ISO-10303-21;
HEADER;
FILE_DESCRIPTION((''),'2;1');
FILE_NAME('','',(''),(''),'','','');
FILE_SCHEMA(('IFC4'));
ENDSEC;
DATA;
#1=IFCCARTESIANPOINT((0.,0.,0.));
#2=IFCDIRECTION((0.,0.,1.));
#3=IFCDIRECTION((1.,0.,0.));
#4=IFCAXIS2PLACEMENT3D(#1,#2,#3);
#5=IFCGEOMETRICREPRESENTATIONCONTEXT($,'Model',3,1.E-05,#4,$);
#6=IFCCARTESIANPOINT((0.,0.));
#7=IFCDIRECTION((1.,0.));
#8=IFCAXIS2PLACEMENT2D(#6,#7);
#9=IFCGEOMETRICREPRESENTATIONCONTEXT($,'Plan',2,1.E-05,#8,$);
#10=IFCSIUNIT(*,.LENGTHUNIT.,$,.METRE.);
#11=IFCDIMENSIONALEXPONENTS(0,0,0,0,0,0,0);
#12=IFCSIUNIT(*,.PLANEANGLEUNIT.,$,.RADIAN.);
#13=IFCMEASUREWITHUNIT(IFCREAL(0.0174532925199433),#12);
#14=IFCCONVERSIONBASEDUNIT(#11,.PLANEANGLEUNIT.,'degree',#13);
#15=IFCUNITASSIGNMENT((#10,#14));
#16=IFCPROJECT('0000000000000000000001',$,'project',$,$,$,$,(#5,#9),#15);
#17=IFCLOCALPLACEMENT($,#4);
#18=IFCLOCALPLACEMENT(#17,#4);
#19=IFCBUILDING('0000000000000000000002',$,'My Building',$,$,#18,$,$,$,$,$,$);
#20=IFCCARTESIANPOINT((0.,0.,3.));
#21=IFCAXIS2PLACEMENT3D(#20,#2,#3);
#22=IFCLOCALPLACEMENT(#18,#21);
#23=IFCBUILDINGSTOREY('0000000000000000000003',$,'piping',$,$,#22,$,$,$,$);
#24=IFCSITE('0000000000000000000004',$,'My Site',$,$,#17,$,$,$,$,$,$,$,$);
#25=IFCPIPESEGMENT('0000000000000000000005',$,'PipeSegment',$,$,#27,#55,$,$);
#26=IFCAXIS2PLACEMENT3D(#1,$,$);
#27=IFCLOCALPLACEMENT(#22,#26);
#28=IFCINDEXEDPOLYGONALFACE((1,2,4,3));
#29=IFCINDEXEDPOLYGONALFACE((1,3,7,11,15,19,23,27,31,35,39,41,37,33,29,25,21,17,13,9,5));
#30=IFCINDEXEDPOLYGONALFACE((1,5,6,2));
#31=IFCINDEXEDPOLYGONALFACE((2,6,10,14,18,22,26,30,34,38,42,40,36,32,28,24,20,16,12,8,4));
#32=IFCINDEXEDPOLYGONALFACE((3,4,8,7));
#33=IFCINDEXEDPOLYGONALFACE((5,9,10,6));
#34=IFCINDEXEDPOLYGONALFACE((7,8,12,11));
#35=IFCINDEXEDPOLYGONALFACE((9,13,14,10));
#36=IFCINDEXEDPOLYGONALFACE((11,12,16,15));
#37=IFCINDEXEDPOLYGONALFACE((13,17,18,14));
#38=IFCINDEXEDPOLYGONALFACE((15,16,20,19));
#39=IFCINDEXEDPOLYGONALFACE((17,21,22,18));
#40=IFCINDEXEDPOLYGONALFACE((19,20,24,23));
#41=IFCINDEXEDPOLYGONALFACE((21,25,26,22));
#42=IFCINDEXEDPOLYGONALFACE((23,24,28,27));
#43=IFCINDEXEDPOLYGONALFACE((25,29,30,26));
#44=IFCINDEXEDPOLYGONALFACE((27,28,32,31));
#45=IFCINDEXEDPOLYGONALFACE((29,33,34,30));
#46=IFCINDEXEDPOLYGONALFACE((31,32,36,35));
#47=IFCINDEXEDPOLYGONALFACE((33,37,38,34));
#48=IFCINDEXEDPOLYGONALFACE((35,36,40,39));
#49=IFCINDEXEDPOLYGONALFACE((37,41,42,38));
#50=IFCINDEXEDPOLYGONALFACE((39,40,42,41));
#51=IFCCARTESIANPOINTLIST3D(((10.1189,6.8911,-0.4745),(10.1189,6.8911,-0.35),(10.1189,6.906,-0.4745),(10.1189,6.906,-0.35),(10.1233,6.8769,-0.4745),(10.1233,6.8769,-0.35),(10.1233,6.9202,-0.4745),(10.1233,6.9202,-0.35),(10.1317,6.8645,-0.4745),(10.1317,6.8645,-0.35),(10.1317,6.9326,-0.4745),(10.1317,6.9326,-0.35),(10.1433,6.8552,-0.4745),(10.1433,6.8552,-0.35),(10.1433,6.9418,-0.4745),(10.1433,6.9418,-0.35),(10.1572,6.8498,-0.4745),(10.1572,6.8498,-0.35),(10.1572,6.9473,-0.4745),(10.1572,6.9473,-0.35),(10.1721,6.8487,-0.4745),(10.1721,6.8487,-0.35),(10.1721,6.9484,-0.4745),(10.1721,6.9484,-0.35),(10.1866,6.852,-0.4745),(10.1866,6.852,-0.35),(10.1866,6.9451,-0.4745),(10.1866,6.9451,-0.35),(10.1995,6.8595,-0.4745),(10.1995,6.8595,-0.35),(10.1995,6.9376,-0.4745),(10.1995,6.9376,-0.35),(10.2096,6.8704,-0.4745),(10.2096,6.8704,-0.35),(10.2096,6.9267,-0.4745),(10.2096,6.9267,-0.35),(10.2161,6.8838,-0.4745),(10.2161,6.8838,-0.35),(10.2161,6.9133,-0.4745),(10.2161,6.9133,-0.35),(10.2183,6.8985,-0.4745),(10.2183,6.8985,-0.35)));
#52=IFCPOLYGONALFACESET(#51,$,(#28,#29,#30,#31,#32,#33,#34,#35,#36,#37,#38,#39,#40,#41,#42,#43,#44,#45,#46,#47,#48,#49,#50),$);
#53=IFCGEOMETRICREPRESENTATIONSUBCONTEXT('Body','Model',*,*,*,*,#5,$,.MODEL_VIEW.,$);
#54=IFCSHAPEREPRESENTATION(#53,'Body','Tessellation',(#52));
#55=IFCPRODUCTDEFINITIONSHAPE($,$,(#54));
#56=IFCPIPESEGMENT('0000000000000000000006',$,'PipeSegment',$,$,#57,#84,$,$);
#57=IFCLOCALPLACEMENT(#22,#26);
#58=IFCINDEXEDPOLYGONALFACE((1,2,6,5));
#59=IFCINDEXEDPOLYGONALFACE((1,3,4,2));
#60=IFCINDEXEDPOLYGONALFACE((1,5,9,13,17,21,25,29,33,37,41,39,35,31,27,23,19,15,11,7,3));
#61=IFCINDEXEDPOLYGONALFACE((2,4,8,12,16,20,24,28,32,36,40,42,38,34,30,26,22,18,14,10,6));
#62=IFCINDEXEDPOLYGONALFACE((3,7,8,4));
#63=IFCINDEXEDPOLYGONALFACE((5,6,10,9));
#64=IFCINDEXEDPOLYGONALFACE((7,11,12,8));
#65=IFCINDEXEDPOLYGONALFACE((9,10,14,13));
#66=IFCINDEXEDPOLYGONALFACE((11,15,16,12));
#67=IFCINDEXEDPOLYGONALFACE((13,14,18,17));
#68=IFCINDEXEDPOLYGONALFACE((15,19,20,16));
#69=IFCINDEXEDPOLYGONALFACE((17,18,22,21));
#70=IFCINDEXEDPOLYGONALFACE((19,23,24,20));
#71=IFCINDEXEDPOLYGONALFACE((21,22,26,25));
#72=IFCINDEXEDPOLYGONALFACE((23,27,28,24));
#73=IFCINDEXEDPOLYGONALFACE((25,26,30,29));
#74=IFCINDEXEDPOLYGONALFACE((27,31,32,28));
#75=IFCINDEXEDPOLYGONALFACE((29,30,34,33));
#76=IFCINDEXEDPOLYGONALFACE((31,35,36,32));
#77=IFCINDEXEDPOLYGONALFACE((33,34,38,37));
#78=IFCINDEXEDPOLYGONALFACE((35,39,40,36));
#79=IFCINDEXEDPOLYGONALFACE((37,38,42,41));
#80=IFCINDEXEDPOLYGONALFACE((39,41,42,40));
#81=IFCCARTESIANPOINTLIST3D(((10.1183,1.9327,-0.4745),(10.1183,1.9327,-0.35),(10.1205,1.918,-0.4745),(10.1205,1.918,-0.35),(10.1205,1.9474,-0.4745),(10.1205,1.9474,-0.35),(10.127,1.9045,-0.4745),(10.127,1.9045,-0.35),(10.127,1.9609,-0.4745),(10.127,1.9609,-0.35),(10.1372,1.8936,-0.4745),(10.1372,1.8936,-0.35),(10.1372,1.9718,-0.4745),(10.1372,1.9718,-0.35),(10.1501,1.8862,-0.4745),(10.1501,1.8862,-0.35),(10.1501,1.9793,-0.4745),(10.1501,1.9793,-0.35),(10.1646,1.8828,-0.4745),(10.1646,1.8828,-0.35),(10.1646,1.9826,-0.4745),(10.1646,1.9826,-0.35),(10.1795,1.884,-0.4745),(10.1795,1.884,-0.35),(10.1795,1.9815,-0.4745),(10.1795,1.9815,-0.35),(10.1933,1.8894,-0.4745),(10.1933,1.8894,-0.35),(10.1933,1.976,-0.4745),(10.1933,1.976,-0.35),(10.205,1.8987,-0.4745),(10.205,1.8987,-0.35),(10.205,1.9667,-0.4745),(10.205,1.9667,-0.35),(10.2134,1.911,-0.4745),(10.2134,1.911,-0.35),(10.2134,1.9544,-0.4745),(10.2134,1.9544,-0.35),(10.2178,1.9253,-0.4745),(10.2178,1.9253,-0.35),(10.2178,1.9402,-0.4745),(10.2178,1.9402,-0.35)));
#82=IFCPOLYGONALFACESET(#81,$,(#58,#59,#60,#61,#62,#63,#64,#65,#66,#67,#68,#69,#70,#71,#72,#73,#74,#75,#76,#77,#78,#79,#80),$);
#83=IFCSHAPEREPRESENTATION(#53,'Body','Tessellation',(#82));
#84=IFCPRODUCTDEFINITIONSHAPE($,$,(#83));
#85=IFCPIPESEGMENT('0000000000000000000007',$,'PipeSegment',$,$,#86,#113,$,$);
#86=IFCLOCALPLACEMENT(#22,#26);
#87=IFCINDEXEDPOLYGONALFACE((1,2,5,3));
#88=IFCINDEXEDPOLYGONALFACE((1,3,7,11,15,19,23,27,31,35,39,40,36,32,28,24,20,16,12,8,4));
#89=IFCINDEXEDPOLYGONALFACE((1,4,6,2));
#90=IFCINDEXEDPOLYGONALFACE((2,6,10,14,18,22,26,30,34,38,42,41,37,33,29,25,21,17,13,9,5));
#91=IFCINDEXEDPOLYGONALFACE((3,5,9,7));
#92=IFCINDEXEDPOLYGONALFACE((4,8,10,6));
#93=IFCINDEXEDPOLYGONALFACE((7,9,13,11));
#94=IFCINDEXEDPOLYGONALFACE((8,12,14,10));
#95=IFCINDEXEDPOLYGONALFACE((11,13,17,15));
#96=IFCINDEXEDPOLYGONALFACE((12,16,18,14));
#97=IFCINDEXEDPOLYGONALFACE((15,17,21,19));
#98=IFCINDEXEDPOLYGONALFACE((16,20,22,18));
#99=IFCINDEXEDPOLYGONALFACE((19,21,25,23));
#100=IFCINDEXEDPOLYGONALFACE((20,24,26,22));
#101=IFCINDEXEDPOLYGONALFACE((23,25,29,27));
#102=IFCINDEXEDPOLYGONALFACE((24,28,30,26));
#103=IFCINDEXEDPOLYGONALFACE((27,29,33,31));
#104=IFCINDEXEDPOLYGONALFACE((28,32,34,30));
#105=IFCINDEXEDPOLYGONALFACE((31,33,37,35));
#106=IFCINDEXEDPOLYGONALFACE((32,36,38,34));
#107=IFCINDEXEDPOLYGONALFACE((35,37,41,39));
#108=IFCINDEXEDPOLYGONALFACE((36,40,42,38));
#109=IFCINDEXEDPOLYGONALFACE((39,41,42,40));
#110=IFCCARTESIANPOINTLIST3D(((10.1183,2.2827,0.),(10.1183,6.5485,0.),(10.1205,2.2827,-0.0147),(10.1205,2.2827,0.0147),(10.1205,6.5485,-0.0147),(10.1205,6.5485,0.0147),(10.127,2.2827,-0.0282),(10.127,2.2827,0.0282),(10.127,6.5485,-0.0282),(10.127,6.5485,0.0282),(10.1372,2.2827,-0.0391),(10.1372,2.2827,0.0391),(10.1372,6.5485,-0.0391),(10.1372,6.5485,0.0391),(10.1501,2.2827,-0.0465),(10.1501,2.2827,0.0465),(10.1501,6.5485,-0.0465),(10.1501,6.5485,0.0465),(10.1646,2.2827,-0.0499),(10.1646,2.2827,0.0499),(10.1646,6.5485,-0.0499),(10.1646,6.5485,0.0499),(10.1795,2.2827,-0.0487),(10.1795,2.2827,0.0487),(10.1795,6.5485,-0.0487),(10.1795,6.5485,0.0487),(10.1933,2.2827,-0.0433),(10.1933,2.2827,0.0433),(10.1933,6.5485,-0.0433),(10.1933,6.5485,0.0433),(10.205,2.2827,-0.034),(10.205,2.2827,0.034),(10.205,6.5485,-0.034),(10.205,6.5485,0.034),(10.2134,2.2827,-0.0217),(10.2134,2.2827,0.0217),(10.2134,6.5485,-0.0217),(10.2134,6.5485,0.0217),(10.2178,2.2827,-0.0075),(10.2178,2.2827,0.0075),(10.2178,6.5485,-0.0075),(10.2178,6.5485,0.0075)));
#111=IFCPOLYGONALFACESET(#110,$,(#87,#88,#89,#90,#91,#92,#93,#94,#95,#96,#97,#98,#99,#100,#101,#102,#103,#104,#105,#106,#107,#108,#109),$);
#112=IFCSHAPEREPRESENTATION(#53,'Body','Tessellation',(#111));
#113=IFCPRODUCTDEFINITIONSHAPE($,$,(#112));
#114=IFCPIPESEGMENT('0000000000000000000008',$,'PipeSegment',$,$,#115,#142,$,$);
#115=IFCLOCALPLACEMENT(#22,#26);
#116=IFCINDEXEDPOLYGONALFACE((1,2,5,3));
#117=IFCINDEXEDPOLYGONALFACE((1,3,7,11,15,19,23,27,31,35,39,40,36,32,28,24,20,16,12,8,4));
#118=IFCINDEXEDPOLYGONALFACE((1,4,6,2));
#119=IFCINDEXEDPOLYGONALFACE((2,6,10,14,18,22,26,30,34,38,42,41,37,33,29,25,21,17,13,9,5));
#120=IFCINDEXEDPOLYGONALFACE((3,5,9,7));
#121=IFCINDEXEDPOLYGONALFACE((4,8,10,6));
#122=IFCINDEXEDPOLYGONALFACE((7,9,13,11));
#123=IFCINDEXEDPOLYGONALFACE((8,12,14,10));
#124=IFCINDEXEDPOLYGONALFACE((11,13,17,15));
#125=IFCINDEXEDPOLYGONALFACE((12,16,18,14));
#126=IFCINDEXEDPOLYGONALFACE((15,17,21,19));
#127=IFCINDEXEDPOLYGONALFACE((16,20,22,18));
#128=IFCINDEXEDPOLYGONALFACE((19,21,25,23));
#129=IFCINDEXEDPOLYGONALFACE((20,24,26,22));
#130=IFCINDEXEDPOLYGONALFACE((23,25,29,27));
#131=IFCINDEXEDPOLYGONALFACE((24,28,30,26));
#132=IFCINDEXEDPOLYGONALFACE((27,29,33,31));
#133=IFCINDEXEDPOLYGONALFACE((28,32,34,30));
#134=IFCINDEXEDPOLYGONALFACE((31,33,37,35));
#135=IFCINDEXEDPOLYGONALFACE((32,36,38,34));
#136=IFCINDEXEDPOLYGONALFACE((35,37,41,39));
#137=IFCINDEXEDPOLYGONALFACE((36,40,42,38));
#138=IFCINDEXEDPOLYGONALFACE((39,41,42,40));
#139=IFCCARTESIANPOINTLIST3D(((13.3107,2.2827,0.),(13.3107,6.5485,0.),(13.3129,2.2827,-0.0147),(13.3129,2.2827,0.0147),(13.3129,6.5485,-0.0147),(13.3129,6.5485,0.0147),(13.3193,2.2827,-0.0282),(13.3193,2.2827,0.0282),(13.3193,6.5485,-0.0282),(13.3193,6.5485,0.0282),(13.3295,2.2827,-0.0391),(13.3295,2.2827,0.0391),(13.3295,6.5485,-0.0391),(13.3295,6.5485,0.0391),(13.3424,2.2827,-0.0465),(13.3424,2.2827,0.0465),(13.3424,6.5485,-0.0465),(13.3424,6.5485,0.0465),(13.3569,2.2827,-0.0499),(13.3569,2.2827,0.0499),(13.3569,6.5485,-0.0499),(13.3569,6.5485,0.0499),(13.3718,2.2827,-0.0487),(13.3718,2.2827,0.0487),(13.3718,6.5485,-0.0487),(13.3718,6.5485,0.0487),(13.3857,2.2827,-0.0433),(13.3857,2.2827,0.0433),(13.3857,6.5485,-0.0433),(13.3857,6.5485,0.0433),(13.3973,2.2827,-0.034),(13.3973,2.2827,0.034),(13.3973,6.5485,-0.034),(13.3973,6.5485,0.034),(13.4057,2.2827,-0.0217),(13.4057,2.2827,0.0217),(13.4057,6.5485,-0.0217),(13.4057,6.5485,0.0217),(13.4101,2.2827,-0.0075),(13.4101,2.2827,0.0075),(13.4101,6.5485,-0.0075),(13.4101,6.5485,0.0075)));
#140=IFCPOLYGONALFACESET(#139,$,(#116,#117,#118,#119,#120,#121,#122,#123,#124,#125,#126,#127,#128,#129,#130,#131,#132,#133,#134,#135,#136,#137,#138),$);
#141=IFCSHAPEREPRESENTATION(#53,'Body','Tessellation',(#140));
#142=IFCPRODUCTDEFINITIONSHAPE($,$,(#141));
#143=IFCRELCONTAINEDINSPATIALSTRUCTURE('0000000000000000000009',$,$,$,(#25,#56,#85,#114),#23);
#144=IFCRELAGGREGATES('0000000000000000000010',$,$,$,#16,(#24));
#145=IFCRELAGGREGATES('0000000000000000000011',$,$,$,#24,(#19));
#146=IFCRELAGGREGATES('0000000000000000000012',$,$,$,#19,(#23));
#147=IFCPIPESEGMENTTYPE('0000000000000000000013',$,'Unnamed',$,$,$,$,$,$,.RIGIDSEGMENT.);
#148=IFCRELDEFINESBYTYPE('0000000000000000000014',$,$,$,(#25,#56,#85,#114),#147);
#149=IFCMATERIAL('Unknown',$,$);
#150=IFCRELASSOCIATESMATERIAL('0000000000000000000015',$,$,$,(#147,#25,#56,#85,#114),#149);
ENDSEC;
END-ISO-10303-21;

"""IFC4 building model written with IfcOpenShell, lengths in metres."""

from ifc_helpers import new_model, entity, si_unit, converted_unit, frame, origin_with_axes, origin_2d_with_axis, place, context, subcontext, project, spatial, circle, extrude, material, material_profile, profile_set, profile_usage, type_object, element, save


model = new_model("IFC4")

# Units and contexts
model_context = context("Model", 3, precision=1e-05, world=origin_with_axes())
plan_context = context("Plan", 2, precision=1e-05, world=origin_2d_with_axis())
body_context = subcontext(model_context, "Body", "Model", "MODEL_VIEW")
ifc_project = project(units=[si_unit("LENGTHUNIT", "METRE"), converted_unit("PLANEANGLEUNIT", "degree", entity("IfcReal", 0.0174532925199433), si_unit("PLANEANGLEUNIT", "RADIAN"), dimensions=[0, 0, 0, 0, 0, 0, 0])], contexts=[model_context, plan_context])

# Site, building, storey
site_placement = place(None, origin_with_axes())
site = spatial("IfcSite", under=ifc_project, at=site_placement, Name="My Site")
building_placement = place(site_placement, origin_with_axes())
building = spatial("IfcBuilding", under=site, at=building_placement, Name="My Building")
storey_placement = place(building_placement, frame((0.0, 0.0, 3.0), z_axis=(0.0, 0.0, 1.0), x_axis=(1.0, 0.0, 0.0)))
storey = spatial("IfcBuildingStorey", under=building, at=storey_placement, Name="piping")

# Pipe segments
ifc_material = material(Name="Unknown")
ifc_material_profile = material_profile(ifc_material, circle(Radius=0.05))
ifc_profile_set = profile_set([ifc_material_profile])
pipe_segment_type = type_object("IfcPipeSegmentType", Name="Unnamed", PredefinedType="RIGIDSEGMENT", material=ifc_profile_set)
ifc_profile_usage_1 = profile_usage(ifc_profile_set, cardinal=5)
pipe_segment_1_placement = place(storey_placement, frame((10.1683, 6.8985, -0.35), z_axis=(0.0, 0.0, -1.0), x_axis=(1.0, 0.0, 0.0)))
element("IfcPipeSegment", 1, at=pipe_segment_1_placement, inside=storey, type_object=pipe_segment_type, material=ifc_profile_usage_1, Name="PipeSegment", context=body_context, shape_type="SweptSolid", body=[
    extrude(circle(Radius=0.05), origin_with_axes(), (0.0, 0.0, 1.0), 0.1245),
])
ifc_profile_usage_2 = profile_usage(ifc_profile_set, cardinal=5)
pipe_segment_2_placement = place(storey_placement, frame((10.1683, 1.9327, -0.35), z_axis=(0.0, 0.0, -1.0), x_axis=(-1.0, 0.0, 0.0)))
element("IfcPipeSegment", 2, at=pipe_segment_2_placement, inside=storey, type_object=pipe_segment_type, material=ifc_profile_usage_2, Name="PipeSegment", context=body_context, shape_type="SweptSolid", body=[
    extrude(circle(Radius=0.05), origin_with_axes(), (0.0, 0.0, 1.0), 0.1245),
])
ifc_profile_usage_3 = profile_usage(ifc_profile_set, cardinal=5)
pipe_segment_3_placement = place(storey_placement, frame((10.1683, 2.2827, 0.0), z_axis=(0.0, 1.0, 0.0), x_axis=(-1.0, 0.0, 0.0)))
element("IfcPipeSegment", 3, at=pipe_segment_3_placement, inside=storey, type_object=pipe_segment_type, material=ifc_profile_usage_3, Name="PipeSegment", context=body_context, shape_type="SweptSolid", body=[
    extrude(circle(Radius=0.05), origin_with_axes(), (0.0, 0.0, 1.0), 4.2658),
])
ifc_profile_usage_4 = profile_usage(ifc_profile_set, cardinal=5)
pipe_segment_4_placement = place(storey_placement, frame((13.3607, 2.2827, 0.0), z_axis=(0.0, 1.0, 0.0), x_axis=(-1.0, 0.0, 0.0)))
element("IfcPipeSegment", 4, at=pipe_segment_4_placement, inside=storey, type_object=pipe_segment_type, material=ifc_profile_usage_4, Name="PipeSegment", context=body_context, shape_type="SweptSolid", body=[
    extrude(circle(Radius=0.05), origin_with_axes(), (0.0, 0.0, 1.0), 4.2658),
])

save(model, "model.ifc")
